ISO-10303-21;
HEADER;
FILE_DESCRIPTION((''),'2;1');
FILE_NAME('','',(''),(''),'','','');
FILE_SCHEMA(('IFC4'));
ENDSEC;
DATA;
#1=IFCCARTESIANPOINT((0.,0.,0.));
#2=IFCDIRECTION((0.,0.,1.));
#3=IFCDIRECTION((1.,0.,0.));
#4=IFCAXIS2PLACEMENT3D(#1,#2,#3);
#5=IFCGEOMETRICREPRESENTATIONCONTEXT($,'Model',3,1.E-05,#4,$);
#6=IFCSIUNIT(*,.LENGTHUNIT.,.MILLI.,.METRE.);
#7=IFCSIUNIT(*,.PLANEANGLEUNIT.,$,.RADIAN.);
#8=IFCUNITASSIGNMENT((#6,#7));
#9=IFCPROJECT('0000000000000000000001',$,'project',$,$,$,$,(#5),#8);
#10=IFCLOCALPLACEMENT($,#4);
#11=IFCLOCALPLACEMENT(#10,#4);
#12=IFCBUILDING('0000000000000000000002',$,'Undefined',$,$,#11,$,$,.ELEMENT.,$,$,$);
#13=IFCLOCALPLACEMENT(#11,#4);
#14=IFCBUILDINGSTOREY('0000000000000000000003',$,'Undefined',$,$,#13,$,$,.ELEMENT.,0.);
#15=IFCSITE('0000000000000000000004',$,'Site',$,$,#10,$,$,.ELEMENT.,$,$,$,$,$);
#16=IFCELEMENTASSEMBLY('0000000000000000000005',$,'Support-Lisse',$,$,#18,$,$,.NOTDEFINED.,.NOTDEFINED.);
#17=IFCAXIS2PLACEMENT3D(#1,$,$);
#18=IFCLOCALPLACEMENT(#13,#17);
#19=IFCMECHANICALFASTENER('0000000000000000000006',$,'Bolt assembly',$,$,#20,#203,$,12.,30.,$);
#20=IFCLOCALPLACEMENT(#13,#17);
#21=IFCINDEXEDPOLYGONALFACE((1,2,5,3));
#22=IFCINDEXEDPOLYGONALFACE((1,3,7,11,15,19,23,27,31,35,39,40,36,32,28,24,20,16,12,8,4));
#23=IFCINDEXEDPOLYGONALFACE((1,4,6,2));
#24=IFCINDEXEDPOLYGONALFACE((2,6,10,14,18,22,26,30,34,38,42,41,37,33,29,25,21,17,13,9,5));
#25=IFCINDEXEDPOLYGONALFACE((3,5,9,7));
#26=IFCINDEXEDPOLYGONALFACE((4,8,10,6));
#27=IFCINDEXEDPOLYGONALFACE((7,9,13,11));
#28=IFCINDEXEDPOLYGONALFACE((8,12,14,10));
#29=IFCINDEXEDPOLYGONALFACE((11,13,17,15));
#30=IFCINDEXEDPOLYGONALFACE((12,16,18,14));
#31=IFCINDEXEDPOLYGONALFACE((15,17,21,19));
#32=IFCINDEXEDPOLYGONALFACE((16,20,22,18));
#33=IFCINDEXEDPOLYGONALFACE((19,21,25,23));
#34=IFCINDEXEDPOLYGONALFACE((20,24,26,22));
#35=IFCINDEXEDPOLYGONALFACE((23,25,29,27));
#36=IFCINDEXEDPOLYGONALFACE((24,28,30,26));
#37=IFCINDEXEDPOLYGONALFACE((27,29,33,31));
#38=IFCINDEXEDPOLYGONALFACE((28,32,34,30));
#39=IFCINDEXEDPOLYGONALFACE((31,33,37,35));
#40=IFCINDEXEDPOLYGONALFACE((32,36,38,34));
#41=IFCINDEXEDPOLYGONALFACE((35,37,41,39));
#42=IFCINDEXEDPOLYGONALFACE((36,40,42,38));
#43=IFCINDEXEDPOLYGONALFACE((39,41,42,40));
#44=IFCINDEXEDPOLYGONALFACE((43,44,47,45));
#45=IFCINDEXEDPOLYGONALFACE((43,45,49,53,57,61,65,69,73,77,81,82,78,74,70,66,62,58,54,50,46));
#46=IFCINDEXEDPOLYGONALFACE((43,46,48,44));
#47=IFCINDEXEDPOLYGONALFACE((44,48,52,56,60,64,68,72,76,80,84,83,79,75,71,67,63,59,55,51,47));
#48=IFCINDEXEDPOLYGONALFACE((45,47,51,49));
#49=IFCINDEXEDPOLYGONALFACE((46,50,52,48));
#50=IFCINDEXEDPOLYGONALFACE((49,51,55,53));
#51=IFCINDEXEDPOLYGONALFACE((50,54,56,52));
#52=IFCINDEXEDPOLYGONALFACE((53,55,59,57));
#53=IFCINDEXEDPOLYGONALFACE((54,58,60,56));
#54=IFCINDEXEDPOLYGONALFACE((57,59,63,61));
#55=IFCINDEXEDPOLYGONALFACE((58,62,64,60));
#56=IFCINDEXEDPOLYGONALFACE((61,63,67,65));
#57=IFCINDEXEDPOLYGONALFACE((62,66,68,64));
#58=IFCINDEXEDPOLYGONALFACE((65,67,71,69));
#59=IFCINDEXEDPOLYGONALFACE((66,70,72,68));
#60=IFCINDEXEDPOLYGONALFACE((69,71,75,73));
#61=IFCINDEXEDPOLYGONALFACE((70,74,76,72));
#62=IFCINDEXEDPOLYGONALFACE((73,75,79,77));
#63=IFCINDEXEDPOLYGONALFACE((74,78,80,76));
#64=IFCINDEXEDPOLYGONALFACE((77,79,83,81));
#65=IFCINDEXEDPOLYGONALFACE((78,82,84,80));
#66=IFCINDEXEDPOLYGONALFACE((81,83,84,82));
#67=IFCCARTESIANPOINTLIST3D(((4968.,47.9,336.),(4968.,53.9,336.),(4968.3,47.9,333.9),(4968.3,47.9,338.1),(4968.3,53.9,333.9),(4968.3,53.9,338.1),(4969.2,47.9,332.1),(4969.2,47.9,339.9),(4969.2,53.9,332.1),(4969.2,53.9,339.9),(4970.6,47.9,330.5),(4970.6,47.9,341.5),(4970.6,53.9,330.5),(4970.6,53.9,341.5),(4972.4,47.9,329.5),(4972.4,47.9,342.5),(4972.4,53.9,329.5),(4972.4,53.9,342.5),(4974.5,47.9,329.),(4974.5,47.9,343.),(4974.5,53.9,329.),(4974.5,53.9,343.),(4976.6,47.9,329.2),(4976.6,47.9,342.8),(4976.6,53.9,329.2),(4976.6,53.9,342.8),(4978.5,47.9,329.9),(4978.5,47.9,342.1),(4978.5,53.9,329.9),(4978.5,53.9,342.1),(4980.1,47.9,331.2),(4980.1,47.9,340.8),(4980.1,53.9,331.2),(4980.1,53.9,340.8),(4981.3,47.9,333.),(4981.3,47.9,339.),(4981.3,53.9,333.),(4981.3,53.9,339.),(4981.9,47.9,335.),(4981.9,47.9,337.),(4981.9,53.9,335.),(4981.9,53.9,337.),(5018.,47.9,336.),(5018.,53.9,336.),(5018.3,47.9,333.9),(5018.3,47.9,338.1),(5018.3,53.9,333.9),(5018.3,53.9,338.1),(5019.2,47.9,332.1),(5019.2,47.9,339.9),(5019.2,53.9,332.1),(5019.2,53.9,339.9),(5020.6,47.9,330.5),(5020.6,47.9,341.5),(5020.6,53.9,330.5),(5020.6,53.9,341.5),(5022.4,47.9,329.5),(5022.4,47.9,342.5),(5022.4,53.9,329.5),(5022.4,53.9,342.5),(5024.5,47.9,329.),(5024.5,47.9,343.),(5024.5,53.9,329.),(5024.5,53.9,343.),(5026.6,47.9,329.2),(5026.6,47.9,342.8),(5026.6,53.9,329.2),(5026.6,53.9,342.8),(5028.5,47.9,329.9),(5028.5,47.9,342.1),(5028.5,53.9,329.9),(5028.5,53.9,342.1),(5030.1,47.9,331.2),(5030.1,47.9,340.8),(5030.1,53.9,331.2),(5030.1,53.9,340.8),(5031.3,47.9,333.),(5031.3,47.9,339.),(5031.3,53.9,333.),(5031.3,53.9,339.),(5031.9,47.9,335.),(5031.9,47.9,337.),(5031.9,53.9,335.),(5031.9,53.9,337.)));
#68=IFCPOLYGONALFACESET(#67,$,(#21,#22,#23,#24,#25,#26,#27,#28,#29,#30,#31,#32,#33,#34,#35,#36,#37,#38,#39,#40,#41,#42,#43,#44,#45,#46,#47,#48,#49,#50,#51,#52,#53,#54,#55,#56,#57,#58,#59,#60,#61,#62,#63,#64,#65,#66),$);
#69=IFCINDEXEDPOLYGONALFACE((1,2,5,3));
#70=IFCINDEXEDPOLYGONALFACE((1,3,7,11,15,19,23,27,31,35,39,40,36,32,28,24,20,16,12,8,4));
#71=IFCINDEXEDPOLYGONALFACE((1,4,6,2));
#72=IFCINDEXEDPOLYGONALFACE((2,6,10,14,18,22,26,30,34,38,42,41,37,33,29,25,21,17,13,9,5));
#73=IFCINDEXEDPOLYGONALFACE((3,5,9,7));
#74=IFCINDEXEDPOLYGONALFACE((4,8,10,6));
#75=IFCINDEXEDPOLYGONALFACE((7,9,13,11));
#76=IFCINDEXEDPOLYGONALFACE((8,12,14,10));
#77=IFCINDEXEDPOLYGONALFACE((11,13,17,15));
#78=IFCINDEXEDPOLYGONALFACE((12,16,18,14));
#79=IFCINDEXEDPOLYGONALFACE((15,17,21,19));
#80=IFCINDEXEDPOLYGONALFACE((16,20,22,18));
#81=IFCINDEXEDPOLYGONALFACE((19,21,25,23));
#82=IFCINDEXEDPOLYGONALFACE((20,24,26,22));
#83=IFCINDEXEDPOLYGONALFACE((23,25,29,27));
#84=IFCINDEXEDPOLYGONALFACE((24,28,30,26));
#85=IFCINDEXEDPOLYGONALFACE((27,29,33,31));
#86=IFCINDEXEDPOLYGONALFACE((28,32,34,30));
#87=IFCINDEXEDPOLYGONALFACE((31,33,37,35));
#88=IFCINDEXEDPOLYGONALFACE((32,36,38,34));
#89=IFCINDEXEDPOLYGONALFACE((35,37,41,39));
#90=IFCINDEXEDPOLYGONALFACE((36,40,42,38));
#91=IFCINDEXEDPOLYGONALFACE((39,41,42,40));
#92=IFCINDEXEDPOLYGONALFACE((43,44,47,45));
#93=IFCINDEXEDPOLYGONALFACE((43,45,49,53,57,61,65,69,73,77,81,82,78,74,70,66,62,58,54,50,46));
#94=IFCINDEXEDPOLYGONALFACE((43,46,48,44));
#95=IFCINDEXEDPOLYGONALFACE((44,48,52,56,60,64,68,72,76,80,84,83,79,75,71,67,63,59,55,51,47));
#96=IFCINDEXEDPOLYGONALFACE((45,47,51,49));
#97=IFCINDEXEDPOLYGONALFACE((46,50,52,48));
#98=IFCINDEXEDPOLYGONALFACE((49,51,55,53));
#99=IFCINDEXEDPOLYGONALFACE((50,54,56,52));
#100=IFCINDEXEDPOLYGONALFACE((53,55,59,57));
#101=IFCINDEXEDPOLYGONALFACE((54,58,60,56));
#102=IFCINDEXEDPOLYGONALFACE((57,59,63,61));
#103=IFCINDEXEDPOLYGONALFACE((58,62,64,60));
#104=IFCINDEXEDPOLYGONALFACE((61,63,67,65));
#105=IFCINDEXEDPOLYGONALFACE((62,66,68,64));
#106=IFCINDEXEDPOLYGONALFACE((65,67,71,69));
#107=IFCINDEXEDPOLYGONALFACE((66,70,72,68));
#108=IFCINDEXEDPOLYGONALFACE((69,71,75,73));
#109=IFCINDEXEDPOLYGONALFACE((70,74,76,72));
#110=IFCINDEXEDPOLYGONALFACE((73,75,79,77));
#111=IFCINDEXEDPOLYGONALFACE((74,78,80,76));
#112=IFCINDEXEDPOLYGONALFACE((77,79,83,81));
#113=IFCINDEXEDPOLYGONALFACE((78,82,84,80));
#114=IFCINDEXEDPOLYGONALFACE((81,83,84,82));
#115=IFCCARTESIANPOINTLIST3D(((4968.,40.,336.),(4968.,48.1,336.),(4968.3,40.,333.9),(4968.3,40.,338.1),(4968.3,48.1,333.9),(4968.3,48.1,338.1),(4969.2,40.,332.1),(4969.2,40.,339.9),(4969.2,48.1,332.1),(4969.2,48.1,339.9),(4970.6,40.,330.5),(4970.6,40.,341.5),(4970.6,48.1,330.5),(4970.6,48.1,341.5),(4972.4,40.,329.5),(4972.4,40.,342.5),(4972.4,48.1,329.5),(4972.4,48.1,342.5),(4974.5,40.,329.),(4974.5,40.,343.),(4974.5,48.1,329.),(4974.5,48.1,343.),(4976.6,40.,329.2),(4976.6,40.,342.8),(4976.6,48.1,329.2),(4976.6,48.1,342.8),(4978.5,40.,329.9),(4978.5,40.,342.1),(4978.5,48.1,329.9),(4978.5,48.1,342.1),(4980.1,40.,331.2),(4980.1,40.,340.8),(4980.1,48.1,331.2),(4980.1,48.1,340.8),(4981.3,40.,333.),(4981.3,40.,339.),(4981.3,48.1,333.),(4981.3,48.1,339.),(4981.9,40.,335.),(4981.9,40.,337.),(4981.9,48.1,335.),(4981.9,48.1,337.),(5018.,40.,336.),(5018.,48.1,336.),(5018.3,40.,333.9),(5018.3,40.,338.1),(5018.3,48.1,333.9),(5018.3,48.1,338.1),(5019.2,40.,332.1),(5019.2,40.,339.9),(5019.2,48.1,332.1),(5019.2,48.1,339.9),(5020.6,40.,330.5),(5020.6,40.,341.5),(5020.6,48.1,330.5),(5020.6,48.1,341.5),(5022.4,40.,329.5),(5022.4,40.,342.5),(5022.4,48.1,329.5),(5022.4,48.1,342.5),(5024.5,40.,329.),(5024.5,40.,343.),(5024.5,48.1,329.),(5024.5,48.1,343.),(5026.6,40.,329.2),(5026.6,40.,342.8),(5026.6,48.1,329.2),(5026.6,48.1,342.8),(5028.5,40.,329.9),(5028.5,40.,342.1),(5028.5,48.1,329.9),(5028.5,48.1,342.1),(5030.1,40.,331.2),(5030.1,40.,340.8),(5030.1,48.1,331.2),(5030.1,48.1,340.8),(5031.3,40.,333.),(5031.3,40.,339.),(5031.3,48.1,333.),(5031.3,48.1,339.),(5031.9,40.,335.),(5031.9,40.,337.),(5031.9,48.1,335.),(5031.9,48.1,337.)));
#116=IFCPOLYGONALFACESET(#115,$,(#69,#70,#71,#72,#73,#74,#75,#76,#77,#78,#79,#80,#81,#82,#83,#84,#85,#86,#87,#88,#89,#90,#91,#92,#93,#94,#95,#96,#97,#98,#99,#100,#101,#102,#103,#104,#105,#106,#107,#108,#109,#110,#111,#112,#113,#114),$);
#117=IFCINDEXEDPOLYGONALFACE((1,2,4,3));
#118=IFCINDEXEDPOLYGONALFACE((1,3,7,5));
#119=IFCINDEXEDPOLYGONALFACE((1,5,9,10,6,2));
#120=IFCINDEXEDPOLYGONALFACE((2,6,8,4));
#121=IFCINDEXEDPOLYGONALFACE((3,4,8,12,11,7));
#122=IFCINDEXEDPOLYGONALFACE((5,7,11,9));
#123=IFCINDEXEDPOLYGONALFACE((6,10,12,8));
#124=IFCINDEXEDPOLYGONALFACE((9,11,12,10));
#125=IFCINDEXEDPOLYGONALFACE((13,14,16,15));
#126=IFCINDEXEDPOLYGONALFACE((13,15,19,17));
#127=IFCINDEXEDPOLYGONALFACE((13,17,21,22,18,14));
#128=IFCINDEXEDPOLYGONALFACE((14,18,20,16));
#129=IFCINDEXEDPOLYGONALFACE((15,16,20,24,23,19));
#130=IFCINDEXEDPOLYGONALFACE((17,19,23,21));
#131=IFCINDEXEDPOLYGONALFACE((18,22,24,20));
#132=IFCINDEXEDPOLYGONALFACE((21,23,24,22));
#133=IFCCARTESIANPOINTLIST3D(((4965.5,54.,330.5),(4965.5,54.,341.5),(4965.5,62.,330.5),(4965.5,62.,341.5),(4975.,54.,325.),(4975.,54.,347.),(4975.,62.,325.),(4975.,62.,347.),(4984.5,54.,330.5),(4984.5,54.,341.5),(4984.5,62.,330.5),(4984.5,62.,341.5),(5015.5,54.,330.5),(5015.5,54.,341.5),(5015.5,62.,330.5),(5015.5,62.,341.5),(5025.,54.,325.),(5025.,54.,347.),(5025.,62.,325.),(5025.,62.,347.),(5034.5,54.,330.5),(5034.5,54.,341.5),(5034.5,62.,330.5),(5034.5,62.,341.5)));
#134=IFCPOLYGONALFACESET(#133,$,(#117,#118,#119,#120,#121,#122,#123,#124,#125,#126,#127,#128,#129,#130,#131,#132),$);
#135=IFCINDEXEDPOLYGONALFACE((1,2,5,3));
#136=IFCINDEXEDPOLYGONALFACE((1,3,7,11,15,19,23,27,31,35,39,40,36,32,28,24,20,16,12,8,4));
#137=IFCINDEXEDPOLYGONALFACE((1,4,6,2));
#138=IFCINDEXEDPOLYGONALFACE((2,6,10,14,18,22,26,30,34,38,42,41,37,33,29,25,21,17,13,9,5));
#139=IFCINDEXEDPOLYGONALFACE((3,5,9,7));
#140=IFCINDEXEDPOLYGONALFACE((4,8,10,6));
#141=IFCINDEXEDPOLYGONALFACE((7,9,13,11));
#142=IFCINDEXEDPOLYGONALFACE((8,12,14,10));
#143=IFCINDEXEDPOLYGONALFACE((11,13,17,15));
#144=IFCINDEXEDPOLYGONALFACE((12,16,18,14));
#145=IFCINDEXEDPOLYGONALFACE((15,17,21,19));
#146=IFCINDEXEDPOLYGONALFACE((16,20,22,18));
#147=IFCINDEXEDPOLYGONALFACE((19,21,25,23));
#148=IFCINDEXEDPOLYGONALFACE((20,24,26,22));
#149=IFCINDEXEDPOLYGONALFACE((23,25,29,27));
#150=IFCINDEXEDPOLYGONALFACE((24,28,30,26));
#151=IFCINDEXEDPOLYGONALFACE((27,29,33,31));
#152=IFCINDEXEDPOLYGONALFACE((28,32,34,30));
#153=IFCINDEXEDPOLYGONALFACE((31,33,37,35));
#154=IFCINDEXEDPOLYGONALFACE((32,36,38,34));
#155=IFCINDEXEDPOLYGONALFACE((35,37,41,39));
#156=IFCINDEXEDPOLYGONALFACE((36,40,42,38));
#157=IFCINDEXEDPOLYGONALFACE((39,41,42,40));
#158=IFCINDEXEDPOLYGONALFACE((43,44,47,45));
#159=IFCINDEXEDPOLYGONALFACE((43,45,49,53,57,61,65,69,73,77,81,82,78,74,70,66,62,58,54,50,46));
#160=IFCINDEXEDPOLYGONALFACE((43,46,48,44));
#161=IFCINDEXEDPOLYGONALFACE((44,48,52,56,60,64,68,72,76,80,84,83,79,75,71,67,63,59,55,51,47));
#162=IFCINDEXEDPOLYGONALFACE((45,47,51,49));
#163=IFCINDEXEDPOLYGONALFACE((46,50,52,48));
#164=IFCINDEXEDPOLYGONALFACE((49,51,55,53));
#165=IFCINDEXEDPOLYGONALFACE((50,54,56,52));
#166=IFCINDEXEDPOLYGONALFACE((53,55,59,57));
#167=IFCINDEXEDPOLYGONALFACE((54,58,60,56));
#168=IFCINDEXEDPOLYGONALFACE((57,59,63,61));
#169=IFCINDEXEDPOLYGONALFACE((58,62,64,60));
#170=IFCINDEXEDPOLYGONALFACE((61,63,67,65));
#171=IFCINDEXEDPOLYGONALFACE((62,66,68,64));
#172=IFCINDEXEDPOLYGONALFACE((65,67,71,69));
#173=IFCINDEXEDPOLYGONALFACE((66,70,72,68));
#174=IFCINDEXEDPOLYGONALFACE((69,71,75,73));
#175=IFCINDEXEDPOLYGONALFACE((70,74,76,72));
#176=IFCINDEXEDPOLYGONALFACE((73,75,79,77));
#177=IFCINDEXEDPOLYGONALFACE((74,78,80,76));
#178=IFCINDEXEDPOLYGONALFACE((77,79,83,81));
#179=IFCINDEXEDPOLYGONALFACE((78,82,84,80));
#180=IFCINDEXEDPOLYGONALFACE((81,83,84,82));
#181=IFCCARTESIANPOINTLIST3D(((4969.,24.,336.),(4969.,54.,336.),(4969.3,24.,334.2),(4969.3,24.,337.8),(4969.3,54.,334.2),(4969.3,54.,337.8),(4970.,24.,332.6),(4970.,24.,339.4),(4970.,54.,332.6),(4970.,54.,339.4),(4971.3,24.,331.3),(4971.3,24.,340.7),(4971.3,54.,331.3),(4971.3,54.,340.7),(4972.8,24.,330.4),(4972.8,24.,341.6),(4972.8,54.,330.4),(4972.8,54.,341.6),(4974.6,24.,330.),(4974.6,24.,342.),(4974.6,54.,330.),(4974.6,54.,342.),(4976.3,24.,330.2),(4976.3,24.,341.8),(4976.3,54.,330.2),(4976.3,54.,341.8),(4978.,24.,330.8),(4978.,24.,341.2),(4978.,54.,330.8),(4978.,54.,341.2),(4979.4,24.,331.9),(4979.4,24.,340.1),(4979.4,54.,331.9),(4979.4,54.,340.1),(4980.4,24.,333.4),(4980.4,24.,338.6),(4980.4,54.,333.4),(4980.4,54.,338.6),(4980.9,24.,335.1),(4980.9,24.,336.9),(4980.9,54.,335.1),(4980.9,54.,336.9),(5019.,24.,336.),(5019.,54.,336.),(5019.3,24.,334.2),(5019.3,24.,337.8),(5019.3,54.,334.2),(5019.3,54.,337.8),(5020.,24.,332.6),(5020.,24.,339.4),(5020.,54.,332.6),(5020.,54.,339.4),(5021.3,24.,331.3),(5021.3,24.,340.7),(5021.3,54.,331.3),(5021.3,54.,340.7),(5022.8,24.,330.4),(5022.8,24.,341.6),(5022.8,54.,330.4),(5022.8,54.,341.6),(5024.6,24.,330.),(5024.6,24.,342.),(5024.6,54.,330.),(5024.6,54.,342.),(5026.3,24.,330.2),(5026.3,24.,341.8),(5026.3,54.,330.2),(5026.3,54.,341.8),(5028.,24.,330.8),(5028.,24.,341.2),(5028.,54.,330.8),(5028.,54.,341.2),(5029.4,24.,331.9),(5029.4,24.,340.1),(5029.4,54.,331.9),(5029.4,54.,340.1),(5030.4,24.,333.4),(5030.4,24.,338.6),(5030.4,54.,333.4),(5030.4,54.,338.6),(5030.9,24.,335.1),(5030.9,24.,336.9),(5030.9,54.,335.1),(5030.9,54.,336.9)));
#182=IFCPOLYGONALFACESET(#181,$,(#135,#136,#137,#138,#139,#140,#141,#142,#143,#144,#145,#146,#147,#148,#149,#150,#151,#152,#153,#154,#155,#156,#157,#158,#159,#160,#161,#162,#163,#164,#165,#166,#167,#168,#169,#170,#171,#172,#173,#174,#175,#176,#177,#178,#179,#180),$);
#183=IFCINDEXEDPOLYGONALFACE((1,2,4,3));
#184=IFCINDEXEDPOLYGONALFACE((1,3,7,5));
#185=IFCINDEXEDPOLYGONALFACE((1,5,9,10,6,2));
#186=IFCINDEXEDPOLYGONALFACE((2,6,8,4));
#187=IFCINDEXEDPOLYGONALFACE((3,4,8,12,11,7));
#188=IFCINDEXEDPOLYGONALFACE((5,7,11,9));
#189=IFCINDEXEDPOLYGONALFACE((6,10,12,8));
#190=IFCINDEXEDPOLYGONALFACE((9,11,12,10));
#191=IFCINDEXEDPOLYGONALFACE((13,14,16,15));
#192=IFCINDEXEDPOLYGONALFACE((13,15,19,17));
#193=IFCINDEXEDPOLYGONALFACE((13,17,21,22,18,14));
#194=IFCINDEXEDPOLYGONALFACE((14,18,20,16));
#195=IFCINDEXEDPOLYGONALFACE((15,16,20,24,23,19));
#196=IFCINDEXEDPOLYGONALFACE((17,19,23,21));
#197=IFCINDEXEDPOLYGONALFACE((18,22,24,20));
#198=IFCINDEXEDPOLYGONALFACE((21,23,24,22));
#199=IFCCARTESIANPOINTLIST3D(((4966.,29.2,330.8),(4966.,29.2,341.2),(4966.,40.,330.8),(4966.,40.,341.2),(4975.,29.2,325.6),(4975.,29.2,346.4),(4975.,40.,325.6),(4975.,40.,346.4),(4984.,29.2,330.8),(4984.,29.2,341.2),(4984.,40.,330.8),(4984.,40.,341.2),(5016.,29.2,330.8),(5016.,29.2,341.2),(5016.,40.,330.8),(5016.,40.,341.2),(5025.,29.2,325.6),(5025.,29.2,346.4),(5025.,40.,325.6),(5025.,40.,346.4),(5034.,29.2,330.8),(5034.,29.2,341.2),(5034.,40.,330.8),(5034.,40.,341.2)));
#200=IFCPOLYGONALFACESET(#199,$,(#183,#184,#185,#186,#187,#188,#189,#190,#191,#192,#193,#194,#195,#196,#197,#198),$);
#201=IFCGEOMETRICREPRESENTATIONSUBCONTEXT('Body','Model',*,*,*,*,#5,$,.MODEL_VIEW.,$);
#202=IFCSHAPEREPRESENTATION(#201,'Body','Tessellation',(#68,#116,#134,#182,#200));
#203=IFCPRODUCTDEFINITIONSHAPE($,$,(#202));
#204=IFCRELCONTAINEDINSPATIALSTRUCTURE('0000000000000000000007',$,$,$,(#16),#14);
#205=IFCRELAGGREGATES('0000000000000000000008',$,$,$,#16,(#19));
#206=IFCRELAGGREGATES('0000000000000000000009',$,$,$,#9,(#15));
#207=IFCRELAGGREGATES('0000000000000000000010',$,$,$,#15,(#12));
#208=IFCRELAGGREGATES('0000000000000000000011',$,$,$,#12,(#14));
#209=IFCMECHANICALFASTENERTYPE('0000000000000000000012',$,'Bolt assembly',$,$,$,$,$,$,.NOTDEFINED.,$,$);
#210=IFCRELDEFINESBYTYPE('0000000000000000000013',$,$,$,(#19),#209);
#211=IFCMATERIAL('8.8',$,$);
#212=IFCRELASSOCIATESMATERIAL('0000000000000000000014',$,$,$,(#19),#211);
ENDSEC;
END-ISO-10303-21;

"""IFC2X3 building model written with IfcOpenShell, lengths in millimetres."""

from ifc_helpers import new_model, si_unit, frame, origin_with_axes, origin_2d_with_axis, place, context, subcontext, project, spatial, polyline, circle, outline, extrude, source, transform, mapped, material, type_object, element, aggregate, save


model = new_model("IFC2X3")

# Units and contexts
model_context = context("Model", 3, precision=1e-05, world=origin_with_axes())
body_context = subcontext(model_context, "Body", "Model", "MODEL_VIEW")
ifc_project = project(units=[si_unit("LENGTHUNIT", "METRE", prefix="MILLI"), si_unit("PLANEANGLEUNIT", "RADIAN")], contexts=[model_context])

# Site, building, storey
site_placement = place(None, origin_with_axes())
site = spatial("IfcSite", under=ifc_project, at=site_placement, Name="Site", CompositionType="ELEMENT")
building_placement = place(site_placement, origin_with_axes())
building = spatial("IfcBuilding", under=site, at=building_placement, Name="Undefined", CompositionType="ELEMENT")
storey_placement = place(building_placement, origin_with_axes())
storey = spatial("IfcBuildingStorey", under=building, at=storey_placement, Name="Undefined", CompositionType="ELEMENT", Elevation=0.0)

# Shared definitions
mechanical_fastener_type = type_object("IfcMechanicalFastenerType", Name="Bolt assembly")

# Element assembly, mechanical fastener
assembly_1_placement = place(storey_placement, origin_with_axes())
assembly_1 = element("IfcElementAssembly", 1, at=assembly_1_placement, inside=storey, Name="Support-Lisse", AssemblyPlace="NOTDEFINED", PredefinedType="NOTDEFINED")
ifc_material_1 = material(Name="8.8")
shared_shape_1 = source(origin_with_axes(), body_context, "Body", "SweptSolid", [
    extrude(circle(Radius=7.0, at=origin_2d_with_axis()), frame((0.0, -5.9, 0.0), z_axis=(0.0, 1.0, 0.0), x_axis=(1.0, 0.0, 0.0)), (0.0, 0.0, 1.0), 6.0),
    extrude(circle(Radius=7.0, at=origin_2d_with_axis()), frame((0.0, -0.1, 0.0), z_axis=(0.0, 1.0, 0.0), x_axis=(1.0, 0.0, 0.0)), (0.0, 0.0, 1.0), 8.1),
    extrude(outline(polyline([(9.5, -5.5), (9.5, 5.5), (0.0, 11.0), (-9.5, 5.5), (-9.5, -5.5), (0.0, -11.0), (9.5, -5.5)])), frame((0.0, -14.0, 0.0), z_axis=(0.0, 1.0, 0.0), x_axis=(1.0, 0.0, 0.0)), (0.0, 0.0, 1.0), 8.0),
    extrude(circle(Radius=6.0, at=origin_2d_with_axis()), frame((0.0, -6.0, 0.0), z_axis=(0.0, 1.0, 0.0), x_axis=(1.0, 0.0, 0.0)), (0.0, 0.0, 1.0), 30.0),
    extrude(outline(polyline([(9.0, -5.2), (9.0, 5.2), (0.0, 10.4), (-9.0, 5.2), (-9.0, -5.2), (0.0, -10.4), (9.0, -5.2)])), frame((0.0, 8.0, 0.0), z_axis=(0.0, 1.0, 0.0), x_axis=(1.0, 0.0, 0.0)), (0.0, 0.0, 1.0), 10.8),
])
mechanical_fastener_1_placement = place(assembly_1_placement, frame((5025.0, 48.0, 336.0), z_axis=(0.0, 0.0, 1.0), x_axis=(-1.0, 0.0, 0.0)))
mechanical_fastener_1 = element("IfcMechanicalFastener", 2, at=mechanical_fastener_1_placement, type_object=mechanical_fastener_type, material=ifc_material_1, Name="Bolt assembly", NominalDiameter=12.0, NominalLength=30.0, context=body_context, shape_type="MappedRepresentation", body=[
    mapped(shared_shape_1, transform((0.0, 0.0, 0.0))),
    mapped(shared_shape_1, transform((50.0, 0.0, 0.0))),
])
aggregate(assembly_1, [mechanical_fastener_1])

save(model, "model.ifc")
